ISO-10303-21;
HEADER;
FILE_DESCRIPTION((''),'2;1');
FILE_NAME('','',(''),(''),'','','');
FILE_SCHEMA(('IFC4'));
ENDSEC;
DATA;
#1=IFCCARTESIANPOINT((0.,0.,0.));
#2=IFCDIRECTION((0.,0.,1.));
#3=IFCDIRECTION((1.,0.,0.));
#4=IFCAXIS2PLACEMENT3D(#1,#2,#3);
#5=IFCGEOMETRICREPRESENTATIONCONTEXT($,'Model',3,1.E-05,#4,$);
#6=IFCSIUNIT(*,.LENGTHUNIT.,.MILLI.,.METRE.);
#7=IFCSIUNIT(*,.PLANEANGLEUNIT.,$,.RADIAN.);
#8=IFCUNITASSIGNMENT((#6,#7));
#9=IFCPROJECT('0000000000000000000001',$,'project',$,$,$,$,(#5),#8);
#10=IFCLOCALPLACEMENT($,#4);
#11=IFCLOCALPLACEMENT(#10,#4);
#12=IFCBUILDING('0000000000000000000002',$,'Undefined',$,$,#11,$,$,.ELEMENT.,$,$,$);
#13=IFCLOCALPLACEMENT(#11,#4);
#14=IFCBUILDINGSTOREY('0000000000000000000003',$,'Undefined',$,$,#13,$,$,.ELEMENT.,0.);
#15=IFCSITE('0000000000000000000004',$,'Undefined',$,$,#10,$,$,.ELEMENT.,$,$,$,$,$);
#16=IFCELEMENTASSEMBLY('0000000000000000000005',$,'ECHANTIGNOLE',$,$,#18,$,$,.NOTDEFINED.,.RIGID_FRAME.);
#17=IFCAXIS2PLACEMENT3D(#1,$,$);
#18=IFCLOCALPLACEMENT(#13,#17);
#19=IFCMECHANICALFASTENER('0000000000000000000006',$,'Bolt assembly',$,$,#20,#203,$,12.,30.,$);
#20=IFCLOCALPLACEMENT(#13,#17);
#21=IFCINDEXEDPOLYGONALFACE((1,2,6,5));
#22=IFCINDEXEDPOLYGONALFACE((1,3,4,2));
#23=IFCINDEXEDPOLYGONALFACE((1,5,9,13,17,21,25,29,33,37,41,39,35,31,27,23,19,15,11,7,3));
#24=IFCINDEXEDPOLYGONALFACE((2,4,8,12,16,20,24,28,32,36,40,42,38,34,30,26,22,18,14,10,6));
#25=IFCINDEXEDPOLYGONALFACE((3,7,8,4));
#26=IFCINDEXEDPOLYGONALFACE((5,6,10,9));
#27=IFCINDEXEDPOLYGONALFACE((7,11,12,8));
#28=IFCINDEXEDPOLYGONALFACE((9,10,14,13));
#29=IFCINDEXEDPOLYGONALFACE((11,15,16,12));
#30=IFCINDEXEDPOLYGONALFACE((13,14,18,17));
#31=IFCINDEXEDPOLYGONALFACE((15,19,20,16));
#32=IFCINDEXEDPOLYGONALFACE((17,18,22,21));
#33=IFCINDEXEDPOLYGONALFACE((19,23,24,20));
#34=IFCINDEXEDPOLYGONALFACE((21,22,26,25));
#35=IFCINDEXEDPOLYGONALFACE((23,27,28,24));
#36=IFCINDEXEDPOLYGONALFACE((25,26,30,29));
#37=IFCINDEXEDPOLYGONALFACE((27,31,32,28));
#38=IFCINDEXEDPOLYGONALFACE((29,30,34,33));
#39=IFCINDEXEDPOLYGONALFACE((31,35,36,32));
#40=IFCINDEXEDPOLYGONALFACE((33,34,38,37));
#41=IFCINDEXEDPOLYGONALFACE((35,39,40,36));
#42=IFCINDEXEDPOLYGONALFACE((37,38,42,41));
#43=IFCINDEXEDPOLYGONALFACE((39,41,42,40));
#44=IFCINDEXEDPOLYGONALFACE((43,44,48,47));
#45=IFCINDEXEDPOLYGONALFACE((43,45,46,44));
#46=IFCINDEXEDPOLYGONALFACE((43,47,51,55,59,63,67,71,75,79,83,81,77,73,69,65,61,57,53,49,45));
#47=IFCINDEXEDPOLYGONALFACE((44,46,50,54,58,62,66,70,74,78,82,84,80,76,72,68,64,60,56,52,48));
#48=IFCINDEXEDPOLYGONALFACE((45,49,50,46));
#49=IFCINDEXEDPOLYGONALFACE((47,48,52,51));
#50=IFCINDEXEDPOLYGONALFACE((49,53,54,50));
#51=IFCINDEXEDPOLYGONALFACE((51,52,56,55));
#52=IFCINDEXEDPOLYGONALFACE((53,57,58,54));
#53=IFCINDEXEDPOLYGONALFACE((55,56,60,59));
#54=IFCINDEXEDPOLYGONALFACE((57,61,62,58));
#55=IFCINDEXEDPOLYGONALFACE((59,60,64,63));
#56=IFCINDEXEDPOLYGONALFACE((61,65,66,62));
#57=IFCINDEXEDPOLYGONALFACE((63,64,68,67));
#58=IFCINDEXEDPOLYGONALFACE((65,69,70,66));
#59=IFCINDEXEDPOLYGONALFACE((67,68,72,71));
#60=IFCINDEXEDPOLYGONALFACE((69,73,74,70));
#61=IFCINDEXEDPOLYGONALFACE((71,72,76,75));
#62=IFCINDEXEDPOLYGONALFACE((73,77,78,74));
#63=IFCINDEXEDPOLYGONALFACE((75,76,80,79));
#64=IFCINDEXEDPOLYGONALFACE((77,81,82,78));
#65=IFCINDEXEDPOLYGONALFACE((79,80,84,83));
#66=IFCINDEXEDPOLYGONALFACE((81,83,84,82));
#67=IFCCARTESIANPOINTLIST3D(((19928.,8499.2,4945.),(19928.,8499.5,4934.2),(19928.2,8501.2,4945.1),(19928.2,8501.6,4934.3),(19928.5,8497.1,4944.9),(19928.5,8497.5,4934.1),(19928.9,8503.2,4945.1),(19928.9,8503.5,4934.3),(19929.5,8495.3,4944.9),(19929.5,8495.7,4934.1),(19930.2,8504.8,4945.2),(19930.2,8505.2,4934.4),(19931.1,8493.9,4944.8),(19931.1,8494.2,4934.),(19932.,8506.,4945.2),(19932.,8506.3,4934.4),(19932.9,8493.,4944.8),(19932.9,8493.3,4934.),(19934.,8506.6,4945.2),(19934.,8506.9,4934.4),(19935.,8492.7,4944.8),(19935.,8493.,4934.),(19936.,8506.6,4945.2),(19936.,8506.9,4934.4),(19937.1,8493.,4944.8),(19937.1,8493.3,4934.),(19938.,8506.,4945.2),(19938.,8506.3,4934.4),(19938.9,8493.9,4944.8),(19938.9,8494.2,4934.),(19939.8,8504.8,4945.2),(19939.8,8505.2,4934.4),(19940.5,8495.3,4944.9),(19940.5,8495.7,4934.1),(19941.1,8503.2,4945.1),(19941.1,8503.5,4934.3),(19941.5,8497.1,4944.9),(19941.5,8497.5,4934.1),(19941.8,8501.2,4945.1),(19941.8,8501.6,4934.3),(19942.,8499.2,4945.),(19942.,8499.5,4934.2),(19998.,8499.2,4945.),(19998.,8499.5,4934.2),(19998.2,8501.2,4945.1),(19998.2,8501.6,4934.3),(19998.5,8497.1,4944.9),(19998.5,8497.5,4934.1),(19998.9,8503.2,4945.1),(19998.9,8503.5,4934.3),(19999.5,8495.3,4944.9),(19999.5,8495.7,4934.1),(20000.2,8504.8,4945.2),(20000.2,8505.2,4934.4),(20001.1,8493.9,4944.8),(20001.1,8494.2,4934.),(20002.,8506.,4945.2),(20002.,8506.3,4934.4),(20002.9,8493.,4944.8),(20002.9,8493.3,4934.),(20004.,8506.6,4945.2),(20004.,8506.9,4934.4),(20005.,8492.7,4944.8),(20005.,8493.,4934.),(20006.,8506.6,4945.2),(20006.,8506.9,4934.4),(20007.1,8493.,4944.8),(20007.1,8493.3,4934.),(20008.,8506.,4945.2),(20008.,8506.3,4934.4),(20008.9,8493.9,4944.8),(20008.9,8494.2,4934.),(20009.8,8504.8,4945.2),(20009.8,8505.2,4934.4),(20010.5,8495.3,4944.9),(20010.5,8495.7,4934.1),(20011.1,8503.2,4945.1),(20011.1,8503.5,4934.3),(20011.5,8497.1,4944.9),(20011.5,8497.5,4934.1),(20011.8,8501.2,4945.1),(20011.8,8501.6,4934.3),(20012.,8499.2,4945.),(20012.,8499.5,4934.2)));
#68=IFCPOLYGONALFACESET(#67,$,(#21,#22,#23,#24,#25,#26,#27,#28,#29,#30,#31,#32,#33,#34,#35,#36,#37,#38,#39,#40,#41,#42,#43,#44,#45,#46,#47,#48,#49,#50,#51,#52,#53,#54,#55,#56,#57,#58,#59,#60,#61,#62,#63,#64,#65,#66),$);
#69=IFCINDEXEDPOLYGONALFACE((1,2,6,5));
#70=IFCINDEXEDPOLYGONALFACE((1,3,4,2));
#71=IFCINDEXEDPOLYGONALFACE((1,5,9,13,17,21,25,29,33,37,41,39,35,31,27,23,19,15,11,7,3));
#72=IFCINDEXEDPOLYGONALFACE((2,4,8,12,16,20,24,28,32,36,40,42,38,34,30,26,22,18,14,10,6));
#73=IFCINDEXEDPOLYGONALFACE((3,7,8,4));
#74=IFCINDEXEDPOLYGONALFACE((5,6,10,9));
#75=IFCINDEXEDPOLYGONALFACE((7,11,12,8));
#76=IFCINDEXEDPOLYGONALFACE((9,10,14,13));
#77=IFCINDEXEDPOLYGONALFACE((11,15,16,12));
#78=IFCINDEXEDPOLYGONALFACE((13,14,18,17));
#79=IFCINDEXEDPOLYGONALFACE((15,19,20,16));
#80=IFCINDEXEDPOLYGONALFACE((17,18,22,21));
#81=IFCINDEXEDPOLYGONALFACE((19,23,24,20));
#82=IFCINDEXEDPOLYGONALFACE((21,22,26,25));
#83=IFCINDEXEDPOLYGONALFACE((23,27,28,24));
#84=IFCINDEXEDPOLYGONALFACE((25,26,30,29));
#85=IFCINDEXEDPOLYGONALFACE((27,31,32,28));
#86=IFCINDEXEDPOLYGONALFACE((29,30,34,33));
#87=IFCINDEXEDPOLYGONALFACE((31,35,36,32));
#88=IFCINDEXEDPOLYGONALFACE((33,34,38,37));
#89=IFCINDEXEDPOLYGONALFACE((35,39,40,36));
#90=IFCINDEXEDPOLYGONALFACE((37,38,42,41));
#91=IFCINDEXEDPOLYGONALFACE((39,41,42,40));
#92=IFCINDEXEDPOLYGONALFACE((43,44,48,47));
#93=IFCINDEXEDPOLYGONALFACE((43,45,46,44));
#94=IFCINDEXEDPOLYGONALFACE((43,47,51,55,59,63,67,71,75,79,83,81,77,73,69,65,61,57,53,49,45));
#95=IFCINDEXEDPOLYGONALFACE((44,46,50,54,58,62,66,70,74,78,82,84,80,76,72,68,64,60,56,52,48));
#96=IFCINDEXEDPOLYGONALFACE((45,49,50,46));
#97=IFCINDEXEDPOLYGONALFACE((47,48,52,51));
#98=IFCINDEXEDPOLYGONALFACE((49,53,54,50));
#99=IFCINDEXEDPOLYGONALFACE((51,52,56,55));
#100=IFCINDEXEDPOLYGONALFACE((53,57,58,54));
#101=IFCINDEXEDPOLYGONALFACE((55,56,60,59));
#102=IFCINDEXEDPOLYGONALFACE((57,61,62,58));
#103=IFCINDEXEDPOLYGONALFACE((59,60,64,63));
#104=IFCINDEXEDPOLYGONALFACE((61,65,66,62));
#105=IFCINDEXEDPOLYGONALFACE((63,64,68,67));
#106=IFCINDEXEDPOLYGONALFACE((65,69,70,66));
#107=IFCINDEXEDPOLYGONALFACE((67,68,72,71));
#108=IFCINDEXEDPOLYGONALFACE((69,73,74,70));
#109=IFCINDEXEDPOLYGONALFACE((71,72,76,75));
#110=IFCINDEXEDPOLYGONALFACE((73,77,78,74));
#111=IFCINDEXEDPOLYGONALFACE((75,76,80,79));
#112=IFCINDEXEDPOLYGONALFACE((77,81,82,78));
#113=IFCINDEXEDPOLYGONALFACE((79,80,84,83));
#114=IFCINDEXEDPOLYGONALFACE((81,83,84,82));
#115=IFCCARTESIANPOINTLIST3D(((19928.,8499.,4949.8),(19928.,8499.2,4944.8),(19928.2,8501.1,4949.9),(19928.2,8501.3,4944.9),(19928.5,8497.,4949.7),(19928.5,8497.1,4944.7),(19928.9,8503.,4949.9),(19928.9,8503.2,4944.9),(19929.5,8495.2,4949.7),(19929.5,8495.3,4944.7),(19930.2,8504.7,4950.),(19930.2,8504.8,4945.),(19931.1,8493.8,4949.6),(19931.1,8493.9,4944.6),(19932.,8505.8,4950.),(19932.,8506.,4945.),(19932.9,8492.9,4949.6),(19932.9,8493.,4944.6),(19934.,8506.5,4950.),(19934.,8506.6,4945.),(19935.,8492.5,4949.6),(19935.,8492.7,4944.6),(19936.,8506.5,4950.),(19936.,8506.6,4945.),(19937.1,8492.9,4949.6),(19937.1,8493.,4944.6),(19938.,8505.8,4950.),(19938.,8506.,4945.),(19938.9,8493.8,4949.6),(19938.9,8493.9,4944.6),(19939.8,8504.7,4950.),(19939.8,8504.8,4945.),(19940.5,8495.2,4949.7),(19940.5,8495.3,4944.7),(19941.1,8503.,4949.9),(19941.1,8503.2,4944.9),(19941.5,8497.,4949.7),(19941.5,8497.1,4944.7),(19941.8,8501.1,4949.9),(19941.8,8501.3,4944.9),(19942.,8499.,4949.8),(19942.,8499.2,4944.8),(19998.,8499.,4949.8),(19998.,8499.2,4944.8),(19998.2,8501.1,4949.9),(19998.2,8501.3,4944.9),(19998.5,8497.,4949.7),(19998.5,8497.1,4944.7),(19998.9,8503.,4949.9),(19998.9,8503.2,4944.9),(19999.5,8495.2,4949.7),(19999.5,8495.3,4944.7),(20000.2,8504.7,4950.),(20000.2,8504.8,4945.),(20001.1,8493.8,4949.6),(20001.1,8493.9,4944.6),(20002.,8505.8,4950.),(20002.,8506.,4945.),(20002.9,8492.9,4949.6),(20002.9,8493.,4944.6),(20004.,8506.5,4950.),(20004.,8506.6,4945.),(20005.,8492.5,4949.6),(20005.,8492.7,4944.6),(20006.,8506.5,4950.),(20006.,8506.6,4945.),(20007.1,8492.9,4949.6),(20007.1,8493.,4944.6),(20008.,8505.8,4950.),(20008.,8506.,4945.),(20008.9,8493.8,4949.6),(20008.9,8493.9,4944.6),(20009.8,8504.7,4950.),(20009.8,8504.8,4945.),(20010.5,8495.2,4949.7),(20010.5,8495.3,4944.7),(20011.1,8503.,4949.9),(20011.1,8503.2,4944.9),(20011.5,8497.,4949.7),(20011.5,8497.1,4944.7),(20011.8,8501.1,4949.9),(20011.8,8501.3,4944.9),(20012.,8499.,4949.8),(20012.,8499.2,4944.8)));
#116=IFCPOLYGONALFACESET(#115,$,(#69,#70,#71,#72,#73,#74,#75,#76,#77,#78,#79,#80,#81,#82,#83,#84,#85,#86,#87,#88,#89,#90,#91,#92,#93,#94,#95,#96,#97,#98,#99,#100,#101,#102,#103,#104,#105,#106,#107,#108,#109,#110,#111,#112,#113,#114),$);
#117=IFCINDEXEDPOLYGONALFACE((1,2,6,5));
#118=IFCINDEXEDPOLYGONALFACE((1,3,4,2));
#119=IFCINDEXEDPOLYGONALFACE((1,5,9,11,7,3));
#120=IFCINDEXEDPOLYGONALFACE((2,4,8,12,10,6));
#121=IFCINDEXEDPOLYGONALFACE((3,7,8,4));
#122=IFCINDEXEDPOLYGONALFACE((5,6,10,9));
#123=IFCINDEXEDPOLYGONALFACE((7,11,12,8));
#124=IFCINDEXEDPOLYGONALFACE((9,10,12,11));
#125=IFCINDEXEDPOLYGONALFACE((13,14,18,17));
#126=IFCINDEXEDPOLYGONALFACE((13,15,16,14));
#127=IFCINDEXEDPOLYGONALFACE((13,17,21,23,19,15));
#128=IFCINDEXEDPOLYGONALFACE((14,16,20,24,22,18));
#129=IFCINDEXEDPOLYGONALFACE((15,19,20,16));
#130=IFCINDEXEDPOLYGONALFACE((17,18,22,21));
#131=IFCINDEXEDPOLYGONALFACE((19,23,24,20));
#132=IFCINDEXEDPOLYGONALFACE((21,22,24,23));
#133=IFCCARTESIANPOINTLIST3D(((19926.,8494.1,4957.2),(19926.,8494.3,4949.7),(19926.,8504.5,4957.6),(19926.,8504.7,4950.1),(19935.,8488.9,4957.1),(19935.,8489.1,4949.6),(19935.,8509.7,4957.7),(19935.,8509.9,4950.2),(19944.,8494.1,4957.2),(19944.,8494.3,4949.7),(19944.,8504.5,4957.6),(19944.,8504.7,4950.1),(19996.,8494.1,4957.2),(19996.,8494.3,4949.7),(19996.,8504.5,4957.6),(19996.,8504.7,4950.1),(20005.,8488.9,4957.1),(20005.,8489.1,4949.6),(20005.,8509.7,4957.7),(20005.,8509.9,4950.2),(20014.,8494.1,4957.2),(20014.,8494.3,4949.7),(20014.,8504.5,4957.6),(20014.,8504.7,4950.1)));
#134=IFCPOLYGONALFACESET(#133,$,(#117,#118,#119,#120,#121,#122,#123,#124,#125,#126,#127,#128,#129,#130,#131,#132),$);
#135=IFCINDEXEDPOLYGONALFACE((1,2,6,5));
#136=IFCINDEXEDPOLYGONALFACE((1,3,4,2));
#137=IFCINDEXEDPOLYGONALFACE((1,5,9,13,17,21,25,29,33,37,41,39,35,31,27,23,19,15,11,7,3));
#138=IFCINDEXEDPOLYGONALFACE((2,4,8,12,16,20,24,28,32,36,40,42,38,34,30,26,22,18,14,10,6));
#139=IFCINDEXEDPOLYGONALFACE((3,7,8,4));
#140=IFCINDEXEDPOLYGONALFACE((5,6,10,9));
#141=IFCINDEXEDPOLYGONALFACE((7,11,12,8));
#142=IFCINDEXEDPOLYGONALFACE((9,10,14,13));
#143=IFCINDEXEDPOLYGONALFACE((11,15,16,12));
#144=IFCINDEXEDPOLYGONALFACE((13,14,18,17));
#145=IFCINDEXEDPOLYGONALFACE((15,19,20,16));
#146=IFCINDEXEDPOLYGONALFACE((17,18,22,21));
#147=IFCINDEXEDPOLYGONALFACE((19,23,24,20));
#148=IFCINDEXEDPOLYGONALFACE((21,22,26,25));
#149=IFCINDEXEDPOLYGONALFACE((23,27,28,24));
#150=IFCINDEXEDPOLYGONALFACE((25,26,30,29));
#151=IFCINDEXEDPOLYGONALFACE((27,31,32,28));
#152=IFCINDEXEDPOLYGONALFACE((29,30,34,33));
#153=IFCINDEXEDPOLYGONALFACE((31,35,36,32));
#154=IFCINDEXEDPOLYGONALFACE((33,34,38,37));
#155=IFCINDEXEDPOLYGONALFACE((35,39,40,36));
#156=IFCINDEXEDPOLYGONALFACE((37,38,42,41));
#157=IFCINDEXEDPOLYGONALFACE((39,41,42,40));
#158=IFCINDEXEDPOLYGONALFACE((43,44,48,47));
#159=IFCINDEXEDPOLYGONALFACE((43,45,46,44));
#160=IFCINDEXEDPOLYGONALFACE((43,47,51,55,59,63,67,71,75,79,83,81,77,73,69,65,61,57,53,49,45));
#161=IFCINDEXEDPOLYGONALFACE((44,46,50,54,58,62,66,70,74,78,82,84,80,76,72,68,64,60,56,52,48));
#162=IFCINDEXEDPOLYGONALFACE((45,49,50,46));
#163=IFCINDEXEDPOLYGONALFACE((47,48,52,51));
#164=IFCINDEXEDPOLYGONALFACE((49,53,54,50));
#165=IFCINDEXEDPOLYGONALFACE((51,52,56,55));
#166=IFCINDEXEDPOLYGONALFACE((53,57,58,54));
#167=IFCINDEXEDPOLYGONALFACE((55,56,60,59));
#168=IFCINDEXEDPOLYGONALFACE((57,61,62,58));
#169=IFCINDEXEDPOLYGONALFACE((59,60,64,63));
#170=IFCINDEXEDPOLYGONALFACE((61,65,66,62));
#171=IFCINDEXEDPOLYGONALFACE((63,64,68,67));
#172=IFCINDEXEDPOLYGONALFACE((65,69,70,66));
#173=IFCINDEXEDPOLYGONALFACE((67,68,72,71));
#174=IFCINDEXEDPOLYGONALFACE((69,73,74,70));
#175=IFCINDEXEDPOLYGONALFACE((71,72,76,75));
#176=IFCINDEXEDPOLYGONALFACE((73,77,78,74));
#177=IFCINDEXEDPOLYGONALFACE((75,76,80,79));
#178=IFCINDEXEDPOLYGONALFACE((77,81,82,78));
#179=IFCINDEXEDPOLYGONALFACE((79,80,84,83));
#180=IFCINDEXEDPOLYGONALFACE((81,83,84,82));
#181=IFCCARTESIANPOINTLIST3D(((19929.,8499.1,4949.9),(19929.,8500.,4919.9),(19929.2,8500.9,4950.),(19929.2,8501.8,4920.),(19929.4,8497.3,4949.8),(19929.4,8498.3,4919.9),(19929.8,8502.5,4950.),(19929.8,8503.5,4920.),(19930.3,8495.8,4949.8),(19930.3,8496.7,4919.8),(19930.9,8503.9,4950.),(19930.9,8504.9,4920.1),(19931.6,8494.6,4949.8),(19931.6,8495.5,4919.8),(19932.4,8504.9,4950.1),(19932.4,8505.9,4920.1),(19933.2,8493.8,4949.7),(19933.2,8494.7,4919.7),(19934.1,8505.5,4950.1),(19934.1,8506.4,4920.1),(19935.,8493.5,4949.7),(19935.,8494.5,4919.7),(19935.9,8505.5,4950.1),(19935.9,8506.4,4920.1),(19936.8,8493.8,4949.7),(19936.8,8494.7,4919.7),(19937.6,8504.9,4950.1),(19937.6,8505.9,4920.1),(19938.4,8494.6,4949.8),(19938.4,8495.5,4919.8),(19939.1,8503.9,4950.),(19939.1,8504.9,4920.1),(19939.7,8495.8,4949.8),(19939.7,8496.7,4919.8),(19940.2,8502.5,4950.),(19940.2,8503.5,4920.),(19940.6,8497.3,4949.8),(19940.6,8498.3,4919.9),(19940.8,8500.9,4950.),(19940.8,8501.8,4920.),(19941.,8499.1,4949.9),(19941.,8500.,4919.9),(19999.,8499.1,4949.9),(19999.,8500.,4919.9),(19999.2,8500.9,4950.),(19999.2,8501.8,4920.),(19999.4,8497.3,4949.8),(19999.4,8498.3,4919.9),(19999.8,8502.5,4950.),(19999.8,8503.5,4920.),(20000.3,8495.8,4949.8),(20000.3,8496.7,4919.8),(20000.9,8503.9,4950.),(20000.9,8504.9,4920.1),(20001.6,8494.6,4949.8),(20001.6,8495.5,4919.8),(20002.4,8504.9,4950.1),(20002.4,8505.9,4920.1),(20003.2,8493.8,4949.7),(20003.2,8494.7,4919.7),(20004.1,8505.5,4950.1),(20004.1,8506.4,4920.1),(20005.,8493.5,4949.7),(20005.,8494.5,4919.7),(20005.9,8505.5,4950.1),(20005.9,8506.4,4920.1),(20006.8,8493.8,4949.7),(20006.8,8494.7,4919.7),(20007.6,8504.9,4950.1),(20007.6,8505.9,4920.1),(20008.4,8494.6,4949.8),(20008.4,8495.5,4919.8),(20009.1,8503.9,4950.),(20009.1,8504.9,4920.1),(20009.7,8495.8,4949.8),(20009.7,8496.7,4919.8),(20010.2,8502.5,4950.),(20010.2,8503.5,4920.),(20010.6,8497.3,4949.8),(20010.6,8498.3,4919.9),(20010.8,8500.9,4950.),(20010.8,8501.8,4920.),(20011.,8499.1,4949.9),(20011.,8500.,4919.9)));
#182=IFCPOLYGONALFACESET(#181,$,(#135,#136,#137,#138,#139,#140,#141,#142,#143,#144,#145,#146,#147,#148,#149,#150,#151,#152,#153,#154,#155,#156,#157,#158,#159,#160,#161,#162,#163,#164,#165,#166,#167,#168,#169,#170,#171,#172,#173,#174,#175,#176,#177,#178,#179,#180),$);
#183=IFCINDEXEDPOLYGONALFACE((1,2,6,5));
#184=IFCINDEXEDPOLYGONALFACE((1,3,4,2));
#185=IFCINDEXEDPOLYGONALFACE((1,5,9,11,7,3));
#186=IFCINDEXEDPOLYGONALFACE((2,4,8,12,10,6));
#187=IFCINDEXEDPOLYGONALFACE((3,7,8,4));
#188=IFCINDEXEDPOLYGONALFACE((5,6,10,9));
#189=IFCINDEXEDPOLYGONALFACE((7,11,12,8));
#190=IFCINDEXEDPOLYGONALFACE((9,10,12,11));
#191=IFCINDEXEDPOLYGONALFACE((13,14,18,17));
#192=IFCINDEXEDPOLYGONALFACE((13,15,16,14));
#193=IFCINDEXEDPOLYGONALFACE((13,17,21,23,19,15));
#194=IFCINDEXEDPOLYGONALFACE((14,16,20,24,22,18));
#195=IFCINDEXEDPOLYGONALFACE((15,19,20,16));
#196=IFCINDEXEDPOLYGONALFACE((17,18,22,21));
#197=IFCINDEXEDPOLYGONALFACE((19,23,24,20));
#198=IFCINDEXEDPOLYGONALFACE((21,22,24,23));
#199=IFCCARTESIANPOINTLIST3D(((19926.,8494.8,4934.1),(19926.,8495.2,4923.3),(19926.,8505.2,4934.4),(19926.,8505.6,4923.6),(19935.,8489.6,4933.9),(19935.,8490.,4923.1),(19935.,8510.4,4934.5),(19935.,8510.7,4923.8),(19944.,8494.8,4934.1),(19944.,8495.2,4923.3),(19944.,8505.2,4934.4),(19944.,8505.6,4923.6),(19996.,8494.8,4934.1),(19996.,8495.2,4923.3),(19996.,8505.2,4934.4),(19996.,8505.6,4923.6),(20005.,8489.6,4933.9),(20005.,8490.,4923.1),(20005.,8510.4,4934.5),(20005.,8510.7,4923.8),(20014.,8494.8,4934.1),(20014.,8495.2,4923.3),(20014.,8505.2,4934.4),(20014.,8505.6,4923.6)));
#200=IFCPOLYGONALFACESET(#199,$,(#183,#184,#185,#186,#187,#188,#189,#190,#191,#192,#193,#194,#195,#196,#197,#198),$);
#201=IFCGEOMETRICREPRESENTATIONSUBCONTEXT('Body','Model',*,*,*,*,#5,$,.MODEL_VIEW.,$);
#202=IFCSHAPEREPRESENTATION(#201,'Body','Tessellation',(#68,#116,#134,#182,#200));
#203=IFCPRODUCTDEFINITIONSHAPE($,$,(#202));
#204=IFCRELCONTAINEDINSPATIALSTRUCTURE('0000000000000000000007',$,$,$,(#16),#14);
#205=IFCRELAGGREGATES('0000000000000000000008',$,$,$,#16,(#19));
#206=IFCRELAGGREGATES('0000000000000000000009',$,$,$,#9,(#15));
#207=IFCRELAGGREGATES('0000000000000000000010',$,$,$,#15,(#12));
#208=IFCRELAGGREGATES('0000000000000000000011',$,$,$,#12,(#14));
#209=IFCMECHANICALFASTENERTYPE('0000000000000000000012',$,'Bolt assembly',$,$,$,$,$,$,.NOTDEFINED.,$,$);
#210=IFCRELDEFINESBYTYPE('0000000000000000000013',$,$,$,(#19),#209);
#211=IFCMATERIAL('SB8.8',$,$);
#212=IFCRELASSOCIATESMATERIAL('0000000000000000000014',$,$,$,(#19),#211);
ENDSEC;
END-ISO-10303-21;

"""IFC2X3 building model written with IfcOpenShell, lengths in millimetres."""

from ifc_helpers import new_model, si_unit, frame, origin_with_axes, origin_2d_with_axis, place, context, subcontext, project, spatial, polyline, circle, outline, extrude, source, transform, mapped, material, type_object, element, aggregate, save


model = new_model("IFC2X3")

# Units and contexts
model_context = context("Model", 3, precision=1e-05, world=origin_with_axes())
body_context = subcontext(model_context, "Body", "Model", "MODEL_VIEW")
ifc_project = project(units=[si_unit("LENGTHUNIT", "METRE", prefix="MILLI"), si_unit("PLANEANGLEUNIT", "RADIAN")], contexts=[model_context])

# Site, building, storey
site_placement = place(None, origin_with_axes())
site = spatial("IfcSite", under=ifc_project, at=site_placement, Name="Undefined", CompositionType="ELEMENT")
building_placement = place(site_placement, origin_with_axes())
building = spatial("IfcBuilding", under=site, at=building_placement, Name="Undefined", CompositionType="ELEMENT")
storey_placement = place(building_placement, origin_with_axes())
storey = spatial("IfcBuildingStorey", under=building, at=storey_placement, Name="Undefined", CompositionType="ELEMENT", Elevation=0.0)

# Shared definitions
ifc_material_1 = material(Name="SB8.8")
mechanical_fastener_type = type_object("IfcMechanicalFastenerType", Name="Bolt assembly")

# Element assembly, mechanical fastener
shared_shape_1 = source(origin_with_axes(), body_context, "Body", "SweptSolid", [
    extrude(circle(Radius=7.0, at=origin_2d_with_axis()), frame((0.0, -0.1, 0.0), z_axis=(0.0, 1.0, 0.0), x_axis=(1.0, 0.0, 0.0)), (0.0, 0.0, 1.0), 10.8),
    extrude(circle(Radius=7.0, at=origin_2d_with_axis()), frame((0.0, -4.9, 0.0), z_axis=(0.0, 1.0, 0.0), x_axis=(1.0, 0.0, 0.0)), (0.0, 0.0, 1.0), 5.0),
    extrude(outline(polyline([(10.4, 0.0), (5.2, 9.0), (-5.2, 9.0), (-10.4, 0.0), (-5.2, -9.0), (5.2, -9.0), (10.4, 0.0)])), frame((0.0, -12.5, 0.0), z_axis=(0.0, 1.0, 0.0), x_axis=(1.0, 0.0, 0.0)), (0.0, 0.0, 1.0), 7.5),
    extrude(circle(Radius=6.0, at=origin_2d_with_axis()), frame((0.0, -5.0, 0.0), z_axis=(0.0, 1.0, 0.0), x_axis=(1.0, 0.0, 0.0)), (0.0, 0.0, 1.0), 30.0),
    extrude(outline(polyline([(10.4, 0.0), (5.2, 9.0), (-5.2, 9.0), (-10.4, 0.0), (-5.2, -9.0), (5.2, -9.0), (10.4, 0.0)])), frame((0.0, 10.7, 0.0), z_axis=(0.0, 1.0, 0.0), x_axis=(1.0, 0.0, 0.0)), (0.0, 0.0, 1.0), 10.8),
])
assembly_1_placement = place(storey_placement, origin_with_axes())
assembly_1 = element("IfcElementAssembly", 1, at=assembly_1_placement, inside=storey, Name="ECHANTIGNOLE", AssemblyPlace="NOTDEFINED", PredefinedType="RIGID_FRAME")
mechanical_fastener_1_placement = place(assembly_1_placement, frame((19970.0, 8499.7, 4944.9), z_axis=(1.0, 0.0, 0.0), x_axis=(0.0, -0.99952, -0.030986)))
mechanical_fastener_1 = element("IfcMechanicalFastener", 2, at=mechanical_fastener_1_placement, type_object=mechanical_fastener_type, material=ifc_material_1, Name="Bolt assembly", NominalDiameter=12.0, NominalLength=30.0, context=body_context, shape_type="MappedRepresentation", body=[
    mapped(shared_shape_1, transform((0.0, 0.0, -35.0))),
    mapped(shared_shape_1, transform((0.0, 0.0, 35.0))),
])
aggregate(assembly_1, [mechanical_fastener_1])

save(model, "model.ifc")
